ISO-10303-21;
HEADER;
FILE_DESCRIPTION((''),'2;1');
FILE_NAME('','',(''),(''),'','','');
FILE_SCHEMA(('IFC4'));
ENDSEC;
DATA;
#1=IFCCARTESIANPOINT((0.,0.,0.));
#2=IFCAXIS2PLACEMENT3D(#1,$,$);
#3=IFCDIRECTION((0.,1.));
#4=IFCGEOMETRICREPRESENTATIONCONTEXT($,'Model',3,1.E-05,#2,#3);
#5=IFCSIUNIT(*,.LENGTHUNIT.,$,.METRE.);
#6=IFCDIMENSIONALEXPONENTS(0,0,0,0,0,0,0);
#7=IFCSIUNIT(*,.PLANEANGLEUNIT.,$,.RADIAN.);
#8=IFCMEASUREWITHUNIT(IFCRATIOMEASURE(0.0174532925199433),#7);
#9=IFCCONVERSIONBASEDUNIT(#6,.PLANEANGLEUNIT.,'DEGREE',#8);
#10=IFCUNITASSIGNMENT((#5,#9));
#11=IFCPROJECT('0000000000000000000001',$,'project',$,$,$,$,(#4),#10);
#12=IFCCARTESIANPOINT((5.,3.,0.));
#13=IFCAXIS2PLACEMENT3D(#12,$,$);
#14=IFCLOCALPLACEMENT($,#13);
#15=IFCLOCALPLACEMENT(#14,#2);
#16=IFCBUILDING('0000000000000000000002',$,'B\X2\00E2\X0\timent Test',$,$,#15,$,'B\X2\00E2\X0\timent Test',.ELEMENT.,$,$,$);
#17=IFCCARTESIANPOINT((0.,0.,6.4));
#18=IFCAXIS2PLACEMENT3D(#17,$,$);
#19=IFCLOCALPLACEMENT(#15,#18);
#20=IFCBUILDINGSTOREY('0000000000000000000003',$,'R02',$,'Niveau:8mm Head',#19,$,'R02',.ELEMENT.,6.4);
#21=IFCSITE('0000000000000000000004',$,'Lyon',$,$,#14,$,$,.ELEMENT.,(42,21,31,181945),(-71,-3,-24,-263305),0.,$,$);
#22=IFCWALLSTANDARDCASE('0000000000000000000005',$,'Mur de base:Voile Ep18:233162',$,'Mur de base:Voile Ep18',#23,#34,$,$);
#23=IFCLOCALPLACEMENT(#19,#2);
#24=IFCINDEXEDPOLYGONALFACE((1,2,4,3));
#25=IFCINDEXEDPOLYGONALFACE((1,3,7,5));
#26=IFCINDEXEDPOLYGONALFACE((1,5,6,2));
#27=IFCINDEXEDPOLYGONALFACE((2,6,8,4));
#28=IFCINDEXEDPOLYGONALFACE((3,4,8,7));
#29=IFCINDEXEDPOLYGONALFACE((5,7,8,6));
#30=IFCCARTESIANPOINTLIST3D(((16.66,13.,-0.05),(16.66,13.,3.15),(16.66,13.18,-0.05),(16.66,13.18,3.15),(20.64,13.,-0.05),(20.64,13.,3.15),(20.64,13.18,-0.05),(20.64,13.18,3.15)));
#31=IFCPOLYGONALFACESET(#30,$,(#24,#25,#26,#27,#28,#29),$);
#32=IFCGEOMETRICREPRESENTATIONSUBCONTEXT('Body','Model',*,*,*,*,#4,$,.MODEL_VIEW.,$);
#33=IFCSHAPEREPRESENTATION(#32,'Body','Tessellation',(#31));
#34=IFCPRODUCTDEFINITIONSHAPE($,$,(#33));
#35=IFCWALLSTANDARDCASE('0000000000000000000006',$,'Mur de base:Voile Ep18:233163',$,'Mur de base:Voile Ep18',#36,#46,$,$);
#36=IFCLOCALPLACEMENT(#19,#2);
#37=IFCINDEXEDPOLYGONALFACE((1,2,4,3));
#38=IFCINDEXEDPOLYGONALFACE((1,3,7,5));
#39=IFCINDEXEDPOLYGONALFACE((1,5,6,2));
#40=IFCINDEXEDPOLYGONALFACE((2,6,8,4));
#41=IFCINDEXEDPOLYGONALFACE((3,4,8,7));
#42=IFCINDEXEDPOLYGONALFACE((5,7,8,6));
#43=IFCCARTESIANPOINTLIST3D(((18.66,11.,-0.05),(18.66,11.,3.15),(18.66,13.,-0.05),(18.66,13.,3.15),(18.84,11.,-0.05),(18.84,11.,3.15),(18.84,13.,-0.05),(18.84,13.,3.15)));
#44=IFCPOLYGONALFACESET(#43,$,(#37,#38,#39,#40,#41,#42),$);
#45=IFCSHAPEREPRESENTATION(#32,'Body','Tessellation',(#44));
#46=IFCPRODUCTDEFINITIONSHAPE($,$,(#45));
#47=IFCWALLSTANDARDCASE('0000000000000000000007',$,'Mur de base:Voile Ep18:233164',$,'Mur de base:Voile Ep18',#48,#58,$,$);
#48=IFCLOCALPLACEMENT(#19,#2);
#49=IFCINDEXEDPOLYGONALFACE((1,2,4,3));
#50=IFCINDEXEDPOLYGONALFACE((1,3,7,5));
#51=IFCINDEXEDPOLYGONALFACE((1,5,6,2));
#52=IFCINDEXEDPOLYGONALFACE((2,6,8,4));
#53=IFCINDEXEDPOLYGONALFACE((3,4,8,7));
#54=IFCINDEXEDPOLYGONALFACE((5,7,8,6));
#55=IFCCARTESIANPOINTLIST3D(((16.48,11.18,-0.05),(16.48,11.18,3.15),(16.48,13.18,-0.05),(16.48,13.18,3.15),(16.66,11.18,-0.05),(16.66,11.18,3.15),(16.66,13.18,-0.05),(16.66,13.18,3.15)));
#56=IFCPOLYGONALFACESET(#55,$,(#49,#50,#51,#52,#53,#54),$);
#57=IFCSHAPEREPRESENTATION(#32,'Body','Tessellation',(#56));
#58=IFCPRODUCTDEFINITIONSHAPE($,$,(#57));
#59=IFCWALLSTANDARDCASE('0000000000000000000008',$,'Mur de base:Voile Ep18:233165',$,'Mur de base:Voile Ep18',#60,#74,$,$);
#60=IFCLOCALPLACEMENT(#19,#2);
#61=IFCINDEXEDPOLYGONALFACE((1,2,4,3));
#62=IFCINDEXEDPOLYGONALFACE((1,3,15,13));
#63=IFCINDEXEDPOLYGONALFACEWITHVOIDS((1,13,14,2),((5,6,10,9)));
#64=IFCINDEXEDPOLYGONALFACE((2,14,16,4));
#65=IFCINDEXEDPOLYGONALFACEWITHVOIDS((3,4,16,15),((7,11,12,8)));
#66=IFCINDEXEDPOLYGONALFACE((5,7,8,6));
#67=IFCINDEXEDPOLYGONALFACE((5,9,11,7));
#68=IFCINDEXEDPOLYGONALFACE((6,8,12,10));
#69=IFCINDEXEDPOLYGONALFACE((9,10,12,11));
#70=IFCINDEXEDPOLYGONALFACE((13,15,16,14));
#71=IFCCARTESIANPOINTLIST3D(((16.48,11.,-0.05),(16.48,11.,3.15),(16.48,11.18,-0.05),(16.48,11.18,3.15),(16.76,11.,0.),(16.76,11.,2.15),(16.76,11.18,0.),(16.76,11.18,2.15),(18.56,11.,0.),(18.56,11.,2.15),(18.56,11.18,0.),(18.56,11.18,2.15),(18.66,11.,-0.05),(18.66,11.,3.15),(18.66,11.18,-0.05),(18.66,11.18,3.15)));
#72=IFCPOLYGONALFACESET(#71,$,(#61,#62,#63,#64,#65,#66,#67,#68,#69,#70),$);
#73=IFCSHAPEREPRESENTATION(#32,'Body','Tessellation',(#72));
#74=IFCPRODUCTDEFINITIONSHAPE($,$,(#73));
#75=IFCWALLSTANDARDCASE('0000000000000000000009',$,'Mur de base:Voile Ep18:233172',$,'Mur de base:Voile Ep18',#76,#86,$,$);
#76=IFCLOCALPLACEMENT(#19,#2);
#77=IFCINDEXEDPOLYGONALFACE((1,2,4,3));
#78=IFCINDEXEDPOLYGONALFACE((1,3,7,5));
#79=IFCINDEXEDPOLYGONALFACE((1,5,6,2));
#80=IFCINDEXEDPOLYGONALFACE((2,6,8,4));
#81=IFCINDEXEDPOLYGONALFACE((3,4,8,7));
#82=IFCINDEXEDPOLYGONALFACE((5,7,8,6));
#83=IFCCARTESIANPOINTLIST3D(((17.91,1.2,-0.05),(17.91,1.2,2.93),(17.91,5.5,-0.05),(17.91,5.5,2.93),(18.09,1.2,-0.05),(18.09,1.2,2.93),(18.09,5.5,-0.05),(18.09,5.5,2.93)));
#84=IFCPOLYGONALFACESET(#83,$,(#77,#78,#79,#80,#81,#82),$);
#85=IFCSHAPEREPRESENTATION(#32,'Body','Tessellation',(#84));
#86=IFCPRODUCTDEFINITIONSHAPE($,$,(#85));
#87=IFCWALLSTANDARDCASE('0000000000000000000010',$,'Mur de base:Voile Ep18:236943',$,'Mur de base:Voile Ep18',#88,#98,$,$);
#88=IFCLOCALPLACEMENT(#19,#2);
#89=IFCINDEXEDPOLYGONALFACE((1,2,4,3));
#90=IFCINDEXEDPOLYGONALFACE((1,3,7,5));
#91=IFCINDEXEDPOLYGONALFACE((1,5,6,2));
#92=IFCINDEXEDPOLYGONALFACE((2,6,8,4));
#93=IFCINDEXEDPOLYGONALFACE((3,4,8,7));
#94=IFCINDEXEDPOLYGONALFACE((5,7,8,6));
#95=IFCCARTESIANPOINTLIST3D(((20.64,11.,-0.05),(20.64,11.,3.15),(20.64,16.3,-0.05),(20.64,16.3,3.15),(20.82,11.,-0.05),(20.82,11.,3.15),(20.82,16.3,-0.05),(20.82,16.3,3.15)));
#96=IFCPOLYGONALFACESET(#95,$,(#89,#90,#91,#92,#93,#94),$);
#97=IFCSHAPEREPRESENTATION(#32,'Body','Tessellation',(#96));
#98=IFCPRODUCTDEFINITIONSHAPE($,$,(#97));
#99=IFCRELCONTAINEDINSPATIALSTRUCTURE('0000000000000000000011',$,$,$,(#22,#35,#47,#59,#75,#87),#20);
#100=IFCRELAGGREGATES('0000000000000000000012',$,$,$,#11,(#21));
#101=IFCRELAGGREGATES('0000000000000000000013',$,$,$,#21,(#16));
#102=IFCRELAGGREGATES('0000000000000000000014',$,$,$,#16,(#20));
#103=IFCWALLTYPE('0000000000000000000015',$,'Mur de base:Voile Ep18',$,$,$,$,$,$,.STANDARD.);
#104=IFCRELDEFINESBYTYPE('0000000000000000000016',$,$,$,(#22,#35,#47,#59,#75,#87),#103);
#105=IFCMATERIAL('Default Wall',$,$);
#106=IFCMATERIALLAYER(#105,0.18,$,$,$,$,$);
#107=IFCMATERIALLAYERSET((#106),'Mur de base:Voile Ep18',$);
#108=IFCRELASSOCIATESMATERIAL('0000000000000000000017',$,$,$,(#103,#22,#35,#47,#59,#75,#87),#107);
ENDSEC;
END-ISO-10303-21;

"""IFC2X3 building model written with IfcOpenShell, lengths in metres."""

from ifc_helpers import new_model, entity, si_unit, converted_unit, direction, frame, frame_2d, origin, place, context, subcontext, project, spatial, rectangle, extrude, material, layer, layer_set, layer_usage, type_object, element, save


model = new_model("IFC2X3")

# Units and contexts
model_context = context("Model", 3, precision=1e-05, world=origin(), true_north=direction((0.0, 1.0)))
body_context = subcontext(model_context, "Body", "Model", "MODEL_VIEW")
ifc_project = project(units=[si_unit("LENGTHUNIT", "METRE"), converted_unit("PLANEANGLEUNIT", "DEGREE", entity("IfcRatioMeasure", 0.0174532925199433), si_unit("PLANEANGLEUNIT", "RADIAN"), dimensions=[0, 0, 0, 0, 0, 0, 0])], contexts=[model_context])

# Site, building, storey
site_placement = place(None, frame((5.0, 3.0, 0.0)))
site = spatial("IfcSite", under=ifc_project, at=site_placement, Name="Lyon", CompositionType="ELEMENT", RefLatitude=(42, 21, 31, 181945), RefLongitude=(-71, -3, -24, -263305), RefElevation=0.0)
building_placement = place(site_placement, origin())
building = spatial("IfcBuilding", under=site, at=building_placement, Name="Bâtiment Test", LongName="Bâtiment Test", CompositionType="ELEMENT")
storey_placement = place(building_placement, frame((0.0, 0.0, 6.4)))
storey = spatial("IfcBuildingStorey", under=building, at=storey_placement, Name="R02", ObjectType="Niveau:8mm Head", LongName="R02", CompositionType="ELEMENT", Elevation=6.4)

# Shared definitions
ifc_material_1 = material(Name="Default Wall")

# Walls
ifc_layer_1 = layer(ifc_material_1, 0.18)
ifc_layer_set_1 = layer_set([ifc_layer_1], Name="Mur de base:Voile Ep18")
ifc_layer_usage_1 = layer_usage(ifc_layer_set_1, "AXIS2", "NEGATIVE", 0.09)
wall_type_1 = type_object("IfcWallType", Name="Mur de base:Voile Ep18", PredefinedType="STANDARD", material=ifc_layer_set_1)
wall_1_placement = place(storey_placement, frame((20.64, 13.09, -0.05), z_axis=(0.0, 0.0, 1.0), x_axis=(-1.0, 0.0, 0.0)))
element("IfcWallStandardCase", 1, at=wall_1_placement, inside=storey, type_object=wall_type_1, material=ifc_layer_usage_1, Name="Mur de base:Voile Ep18:233162", ObjectType="Mur de base:Voile Ep18", context=body_context, shape_type="SweptSolid", body=[
    extrude(rectangle(XDim=3.98, YDim=0.18, at=frame_2d((1.99, 0.0), x_axis=(-1.0, 0.0))), origin(), (0.0, 0.0, 1.0), 3.2),
])
ifc_layer_usage_2 = layer_usage(ifc_layer_set_1, "AXIS2", "NEGATIVE", 0.09)
wall_2_placement = place(storey_placement, frame((18.75, 13.0, -0.05), z_axis=(0.0, 0.0, 1.0), x_axis=(0.0, -1.0, 0.0)))
element("IfcWallStandardCase", 2, at=wall_2_placement, inside=storey, type_object=wall_type_1, material=ifc_layer_usage_2, Name="Mur de base:Voile Ep18:233163", ObjectType="Mur de base:Voile Ep18", context=body_context, shape_type="SweptSolid", body=[
    extrude(rectangle(XDim=2.0, YDim=0.18, at=frame_2d((1.0, 0.0), x_axis=(-1.0, 0.0))), origin(), (0.0, 0.0, 1.0), 3.2),
])
ifc_layer_usage_3 = layer_usage(ifc_layer_set_1, "AXIS2", "NEGATIVE", 0.09)
wall_3_placement = place(storey_placement, frame((16.57, 13.18, -0.05), z_axis=(0.0, 0.0, 1.0), x_axis=(0.0, -1.0, 0.0)))
element("IfcWallStandardCase", 3, at=wall_3_placement, inside=storey, type_object=wall_type_1, material=ifc_layer_usage_3, Name="Mur de base:Voile Ep18:233164", ObjectType="Mur de base:Voile Ep18", context=body_context, shape_type="SweptSolid", body=[
    extrude(rectangle(XDim=2.0, YDim=0.18, at=frame_2d((1.0, 0.0), x_axis=(-1.0, 0.0))), origin(), (0.0, 0.0, 1.0), 3.2),
])

# Wall, opening
ifc_layer_usage_4 = layer_usage(ifc_layer_set_1, "AXIS2", "POSITIVE", -0.09)
wall_4_placement = place(storey_placement, frame((16.48, 11.09, -0.05)))
wall_4 = element("IfcWallStandardCase", 4, at=wall_4_placement, inside=storey, type_object=wall_type_1, material=ifc_layer_usage_4, Name="Mur de base:Voile Ep18:233165", ObjectType="Mur de base:Voile Ep18", context=body_context, shape_type="SweptSolid", body=[
    extrude(rectangle(XDim=2.18, YDim=0.18, at=frame_2d((1.09, 0.0), x_axis=(-1.0, 0.0))), origin(), (0.0, 0.0, 1.0), 3.2),
])
opening_1_placement = place(wall_4_placement, origin())
element("IfcOpeningElement", 5, at=opening_1_placement, cuts=wall_4, ObjectType="Opening", context=body_context, shape_type="SweptSolid", body=[
    extrude(rectangle(XDim=2.15, YDim=1.8, at=frame_2d((0.0, 0.0), x_axis=(0.0, 1.0))), frame((1.18, -0.09, 1.125), z_axis=(0.0, 1.0, 0.0), x_axis=(1.0, 0.0, 0.0)), (0.0, 0.0, 1.0), 0.18),
])

# Walls
ifc_layer_usage_5 = layer_usage(ifc_layer_set_1, "AXIS2", "NEGATIVE", 0.09)
wall_5_placement = place(storey_placement, frame((18.0, 1.2, -0.05), z_axis=(0.0, 0.0, 1.0), x_axis=(0.0, 1.0, 0.0)))
element("IfcWallStandardCase", 6, at=wall_5_placement, inside=storey, type_object=wall_type_1, material=ifc_layer_usage_5, Name="Mur de base:Voile Ep18:233172", ObjectType="Mur de base:Voile Ep18", context=body_context, shape_type="SweptSolid", body=[
    extrude(rectangle(XDim=4.3, YDim=0.18, at=frame_2d((2.15, 0.0), x_axis=(-1.0, 0.0))), origin(), (0.0, 0.0, 1.0), 2.98),
])
ifc_layer_usage_6 = layer_usage(ifc_layer_set_1, "AXIS2", "NEGATIVE", 0.09)
wall_6_placement = place(storey_placement, frame((20.73, 16.3, -0.05), z_axis=(0.0, 0.0, 1.0), x_axis=(0.0, -1.0, 0.0)))
element("IfcWallStandardCase", 7, at=wall_6_placement, inside=storey, type_object=wall_type_1, material=ifc_layer_usage_6, Name="Mur de base:Voile Ep18:236943", ObjectType="Mur de base:Voile Ep18", context=body_context, shape_type="SweptSolid", body=[
    extrude(rectangle(XDim=5.3, YDim=0.18, at=frame_2d((2.65, 0.0), x_axis=(-1.0, 0.0))), origin(), (0.0, 0.0, 1.0), 3.2),
])

save(model, "model.ifc")
